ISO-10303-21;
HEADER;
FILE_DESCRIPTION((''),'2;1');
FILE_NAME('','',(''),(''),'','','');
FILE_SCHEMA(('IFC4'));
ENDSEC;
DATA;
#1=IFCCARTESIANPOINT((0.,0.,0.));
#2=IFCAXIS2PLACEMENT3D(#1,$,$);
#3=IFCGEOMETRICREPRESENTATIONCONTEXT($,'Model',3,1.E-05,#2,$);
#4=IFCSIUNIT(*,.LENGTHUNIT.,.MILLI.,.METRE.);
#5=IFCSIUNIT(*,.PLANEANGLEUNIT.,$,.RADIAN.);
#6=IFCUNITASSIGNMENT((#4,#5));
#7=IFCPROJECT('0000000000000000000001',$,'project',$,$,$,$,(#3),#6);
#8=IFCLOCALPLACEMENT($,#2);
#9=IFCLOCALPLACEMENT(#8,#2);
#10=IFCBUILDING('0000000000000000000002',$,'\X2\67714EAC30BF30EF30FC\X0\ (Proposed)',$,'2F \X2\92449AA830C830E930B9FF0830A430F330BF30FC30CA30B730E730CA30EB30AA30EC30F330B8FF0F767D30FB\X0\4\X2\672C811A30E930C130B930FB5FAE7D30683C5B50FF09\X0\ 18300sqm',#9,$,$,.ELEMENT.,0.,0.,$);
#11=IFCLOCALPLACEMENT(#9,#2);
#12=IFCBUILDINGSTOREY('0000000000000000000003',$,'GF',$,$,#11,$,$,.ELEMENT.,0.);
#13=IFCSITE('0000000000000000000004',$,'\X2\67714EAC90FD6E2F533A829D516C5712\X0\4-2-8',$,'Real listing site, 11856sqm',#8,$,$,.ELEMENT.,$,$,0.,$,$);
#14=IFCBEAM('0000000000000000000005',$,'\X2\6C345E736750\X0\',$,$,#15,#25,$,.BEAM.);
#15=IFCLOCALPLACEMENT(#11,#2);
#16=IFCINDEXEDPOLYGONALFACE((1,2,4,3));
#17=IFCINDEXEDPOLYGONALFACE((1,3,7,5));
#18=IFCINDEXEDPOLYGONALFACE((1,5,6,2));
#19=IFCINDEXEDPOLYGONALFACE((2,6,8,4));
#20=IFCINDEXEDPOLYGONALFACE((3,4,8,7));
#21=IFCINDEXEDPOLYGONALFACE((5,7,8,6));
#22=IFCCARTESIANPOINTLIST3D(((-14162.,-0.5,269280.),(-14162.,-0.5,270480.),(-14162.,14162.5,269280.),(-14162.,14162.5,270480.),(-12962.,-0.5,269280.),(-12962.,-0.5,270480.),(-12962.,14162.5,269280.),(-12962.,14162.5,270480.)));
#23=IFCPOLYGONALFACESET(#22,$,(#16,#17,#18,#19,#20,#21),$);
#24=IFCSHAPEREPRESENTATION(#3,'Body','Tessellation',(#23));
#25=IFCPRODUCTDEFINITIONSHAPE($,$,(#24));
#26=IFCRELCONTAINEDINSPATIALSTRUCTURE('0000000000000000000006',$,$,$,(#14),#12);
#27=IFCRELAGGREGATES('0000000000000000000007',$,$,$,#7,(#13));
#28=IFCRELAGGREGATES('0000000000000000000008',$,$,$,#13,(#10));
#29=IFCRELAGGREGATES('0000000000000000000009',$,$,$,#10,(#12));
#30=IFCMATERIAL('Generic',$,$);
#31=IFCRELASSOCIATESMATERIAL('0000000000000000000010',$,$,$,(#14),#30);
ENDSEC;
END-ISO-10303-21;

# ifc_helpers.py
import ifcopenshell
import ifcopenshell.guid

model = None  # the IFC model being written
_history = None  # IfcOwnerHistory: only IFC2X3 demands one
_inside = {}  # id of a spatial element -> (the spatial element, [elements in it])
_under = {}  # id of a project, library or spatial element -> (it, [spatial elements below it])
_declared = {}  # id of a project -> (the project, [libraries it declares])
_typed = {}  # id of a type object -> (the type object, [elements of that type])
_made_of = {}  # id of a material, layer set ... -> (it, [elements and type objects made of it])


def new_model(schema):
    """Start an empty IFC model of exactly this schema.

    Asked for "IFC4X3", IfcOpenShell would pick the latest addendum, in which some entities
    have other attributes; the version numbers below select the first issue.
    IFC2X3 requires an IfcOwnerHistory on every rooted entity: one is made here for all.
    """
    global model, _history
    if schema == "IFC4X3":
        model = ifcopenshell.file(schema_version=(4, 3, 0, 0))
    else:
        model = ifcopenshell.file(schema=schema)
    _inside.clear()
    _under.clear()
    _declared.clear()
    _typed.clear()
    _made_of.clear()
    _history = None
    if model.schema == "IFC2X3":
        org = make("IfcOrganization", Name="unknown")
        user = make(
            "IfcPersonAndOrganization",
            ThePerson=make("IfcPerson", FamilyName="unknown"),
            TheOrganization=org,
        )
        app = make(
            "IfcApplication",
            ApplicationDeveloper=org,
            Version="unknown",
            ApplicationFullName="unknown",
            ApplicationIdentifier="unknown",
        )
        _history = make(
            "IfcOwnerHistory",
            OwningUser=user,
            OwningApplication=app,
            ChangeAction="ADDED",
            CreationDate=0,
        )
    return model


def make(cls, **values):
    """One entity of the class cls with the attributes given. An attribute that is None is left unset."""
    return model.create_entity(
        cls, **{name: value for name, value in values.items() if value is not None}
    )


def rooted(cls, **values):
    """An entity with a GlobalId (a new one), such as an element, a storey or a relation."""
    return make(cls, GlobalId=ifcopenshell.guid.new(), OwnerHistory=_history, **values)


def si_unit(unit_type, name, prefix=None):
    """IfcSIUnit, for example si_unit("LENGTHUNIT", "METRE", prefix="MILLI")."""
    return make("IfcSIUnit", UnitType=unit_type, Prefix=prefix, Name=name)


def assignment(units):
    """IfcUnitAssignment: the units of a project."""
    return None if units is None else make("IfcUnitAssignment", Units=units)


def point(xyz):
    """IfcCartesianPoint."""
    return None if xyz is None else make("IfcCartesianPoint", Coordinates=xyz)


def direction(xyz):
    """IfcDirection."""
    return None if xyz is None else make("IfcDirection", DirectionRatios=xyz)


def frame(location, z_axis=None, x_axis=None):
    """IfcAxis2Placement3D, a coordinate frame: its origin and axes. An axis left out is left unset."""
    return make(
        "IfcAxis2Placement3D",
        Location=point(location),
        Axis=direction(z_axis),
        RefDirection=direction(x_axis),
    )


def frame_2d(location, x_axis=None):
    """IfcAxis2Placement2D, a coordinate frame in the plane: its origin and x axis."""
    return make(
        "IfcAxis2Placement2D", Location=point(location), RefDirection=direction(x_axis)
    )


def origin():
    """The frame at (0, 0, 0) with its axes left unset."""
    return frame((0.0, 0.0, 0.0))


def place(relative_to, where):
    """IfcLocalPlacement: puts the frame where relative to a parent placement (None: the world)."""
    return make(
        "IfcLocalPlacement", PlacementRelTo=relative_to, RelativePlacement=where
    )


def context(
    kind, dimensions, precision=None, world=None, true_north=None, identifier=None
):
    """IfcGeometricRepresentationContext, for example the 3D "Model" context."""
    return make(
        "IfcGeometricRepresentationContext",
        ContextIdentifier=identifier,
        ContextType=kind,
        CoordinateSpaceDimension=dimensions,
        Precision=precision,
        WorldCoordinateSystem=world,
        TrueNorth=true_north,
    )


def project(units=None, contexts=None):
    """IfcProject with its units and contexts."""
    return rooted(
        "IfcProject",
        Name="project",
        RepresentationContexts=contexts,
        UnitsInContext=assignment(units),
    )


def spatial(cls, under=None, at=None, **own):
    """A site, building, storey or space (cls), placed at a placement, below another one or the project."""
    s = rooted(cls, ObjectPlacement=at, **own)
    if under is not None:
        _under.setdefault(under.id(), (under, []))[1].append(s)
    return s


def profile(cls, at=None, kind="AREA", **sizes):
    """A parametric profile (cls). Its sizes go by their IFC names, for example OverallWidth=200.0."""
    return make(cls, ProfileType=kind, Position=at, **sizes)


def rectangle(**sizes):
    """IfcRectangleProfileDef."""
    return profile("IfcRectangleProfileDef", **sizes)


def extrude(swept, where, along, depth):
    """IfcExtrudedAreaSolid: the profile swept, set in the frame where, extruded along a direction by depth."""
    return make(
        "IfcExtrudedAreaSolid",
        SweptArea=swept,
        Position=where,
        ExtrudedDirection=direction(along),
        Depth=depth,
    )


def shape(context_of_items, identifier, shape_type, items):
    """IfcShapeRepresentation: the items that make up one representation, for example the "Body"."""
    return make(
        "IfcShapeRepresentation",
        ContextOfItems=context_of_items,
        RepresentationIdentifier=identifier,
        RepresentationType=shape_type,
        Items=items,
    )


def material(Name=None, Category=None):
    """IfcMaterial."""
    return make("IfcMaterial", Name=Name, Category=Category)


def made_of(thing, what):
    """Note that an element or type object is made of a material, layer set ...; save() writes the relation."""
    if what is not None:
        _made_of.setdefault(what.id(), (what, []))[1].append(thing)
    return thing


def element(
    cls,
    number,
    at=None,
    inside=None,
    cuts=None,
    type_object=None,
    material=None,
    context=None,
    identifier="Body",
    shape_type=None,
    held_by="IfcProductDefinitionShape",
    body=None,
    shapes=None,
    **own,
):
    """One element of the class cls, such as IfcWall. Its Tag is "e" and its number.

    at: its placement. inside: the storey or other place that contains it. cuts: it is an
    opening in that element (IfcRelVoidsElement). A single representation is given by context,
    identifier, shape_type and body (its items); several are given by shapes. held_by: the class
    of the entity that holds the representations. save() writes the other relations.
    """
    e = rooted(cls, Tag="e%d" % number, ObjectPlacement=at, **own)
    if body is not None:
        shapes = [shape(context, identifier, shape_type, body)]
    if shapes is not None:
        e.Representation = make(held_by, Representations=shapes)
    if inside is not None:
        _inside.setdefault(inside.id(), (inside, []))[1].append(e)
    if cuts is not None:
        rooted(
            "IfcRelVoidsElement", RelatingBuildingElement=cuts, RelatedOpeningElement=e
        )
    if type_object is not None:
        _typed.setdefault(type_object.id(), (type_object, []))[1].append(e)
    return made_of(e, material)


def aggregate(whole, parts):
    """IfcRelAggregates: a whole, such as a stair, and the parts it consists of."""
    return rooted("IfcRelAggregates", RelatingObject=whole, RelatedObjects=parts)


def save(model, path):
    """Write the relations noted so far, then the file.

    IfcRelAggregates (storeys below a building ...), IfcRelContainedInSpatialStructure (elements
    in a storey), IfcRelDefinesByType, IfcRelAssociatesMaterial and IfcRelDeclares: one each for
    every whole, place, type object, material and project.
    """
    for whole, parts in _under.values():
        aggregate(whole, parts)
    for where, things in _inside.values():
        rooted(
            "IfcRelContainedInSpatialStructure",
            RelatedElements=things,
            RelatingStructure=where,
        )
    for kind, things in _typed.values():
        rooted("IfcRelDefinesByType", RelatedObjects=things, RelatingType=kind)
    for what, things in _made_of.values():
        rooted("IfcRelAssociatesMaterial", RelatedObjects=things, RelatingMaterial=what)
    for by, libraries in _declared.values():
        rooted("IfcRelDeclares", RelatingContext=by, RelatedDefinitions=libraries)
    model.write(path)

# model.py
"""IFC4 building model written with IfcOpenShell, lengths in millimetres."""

from ifc_helpers import new_model, si_unit, frame, frame_2d, origin, place, context, project, spatial, rectangle, extrude, material, element, save


model = new_model("IFC4")

# Units and contexts
model_context = context("Model", 3, precision=1e-05, world=origin())
ifc_project = project(units=[si_unit("LENGTHUNIT", "METRE", prefix="MILLI"), si_unit("PLANEANGLEUNIT", "RADIAN")], contexts=[model_context])

# Site, building, storey
site_placement = place(None, origin())
site = spatial("IfcSite", under=ifc_project, at=site_placement, Name="東京都港区芝公園4-2-8", ObjectType="Real listing site, 11856sqm", CompositionType="ELEMENT", RefElevation=0.0)
building_placement = place(site_placement, origin())
building = spatial("IfcBuilding", under=site, at=building_placement, Name="東京タワー (Proposed)", ObjectType="2F 鉄骨トラス（インターナショナルオレンジ／白・4本脚ラチス・微細格子） 18300sqm", CompositionType="ELEMENT", ElevationOfRefHeight=0.0, ElevationOfTerrain=0.0)
storey_placement = place(building_placement, origin())
storey = spatial("IfcBuildingStorey", under=building, at=storey_placement, Name="GF", CompositionType="ELEMENT", Elevation=0.0)

# Shared definitions
ifc_material = material(Name="Generic")

# Beam
beam_placement = place(storey_placement, frame((-7081.0, 0.0, 134640.0)))
element("IfcBeam", 1, at=beam_placement, inside=storey, material=ifc_material, Name="水平材", PredefinedType="BEAM", context=model_context, shape_type="SweptSolid", body=[
    extrude(rectangle(XDim=1200.0, YDim=14163.0, at=frame_2d((600.0, 7081.0))), frame((-7081.0, 0.0, 134640.0)), (0.0, 0.0, 1.0), 1200.0),
])

save(model, "model.ifc")
